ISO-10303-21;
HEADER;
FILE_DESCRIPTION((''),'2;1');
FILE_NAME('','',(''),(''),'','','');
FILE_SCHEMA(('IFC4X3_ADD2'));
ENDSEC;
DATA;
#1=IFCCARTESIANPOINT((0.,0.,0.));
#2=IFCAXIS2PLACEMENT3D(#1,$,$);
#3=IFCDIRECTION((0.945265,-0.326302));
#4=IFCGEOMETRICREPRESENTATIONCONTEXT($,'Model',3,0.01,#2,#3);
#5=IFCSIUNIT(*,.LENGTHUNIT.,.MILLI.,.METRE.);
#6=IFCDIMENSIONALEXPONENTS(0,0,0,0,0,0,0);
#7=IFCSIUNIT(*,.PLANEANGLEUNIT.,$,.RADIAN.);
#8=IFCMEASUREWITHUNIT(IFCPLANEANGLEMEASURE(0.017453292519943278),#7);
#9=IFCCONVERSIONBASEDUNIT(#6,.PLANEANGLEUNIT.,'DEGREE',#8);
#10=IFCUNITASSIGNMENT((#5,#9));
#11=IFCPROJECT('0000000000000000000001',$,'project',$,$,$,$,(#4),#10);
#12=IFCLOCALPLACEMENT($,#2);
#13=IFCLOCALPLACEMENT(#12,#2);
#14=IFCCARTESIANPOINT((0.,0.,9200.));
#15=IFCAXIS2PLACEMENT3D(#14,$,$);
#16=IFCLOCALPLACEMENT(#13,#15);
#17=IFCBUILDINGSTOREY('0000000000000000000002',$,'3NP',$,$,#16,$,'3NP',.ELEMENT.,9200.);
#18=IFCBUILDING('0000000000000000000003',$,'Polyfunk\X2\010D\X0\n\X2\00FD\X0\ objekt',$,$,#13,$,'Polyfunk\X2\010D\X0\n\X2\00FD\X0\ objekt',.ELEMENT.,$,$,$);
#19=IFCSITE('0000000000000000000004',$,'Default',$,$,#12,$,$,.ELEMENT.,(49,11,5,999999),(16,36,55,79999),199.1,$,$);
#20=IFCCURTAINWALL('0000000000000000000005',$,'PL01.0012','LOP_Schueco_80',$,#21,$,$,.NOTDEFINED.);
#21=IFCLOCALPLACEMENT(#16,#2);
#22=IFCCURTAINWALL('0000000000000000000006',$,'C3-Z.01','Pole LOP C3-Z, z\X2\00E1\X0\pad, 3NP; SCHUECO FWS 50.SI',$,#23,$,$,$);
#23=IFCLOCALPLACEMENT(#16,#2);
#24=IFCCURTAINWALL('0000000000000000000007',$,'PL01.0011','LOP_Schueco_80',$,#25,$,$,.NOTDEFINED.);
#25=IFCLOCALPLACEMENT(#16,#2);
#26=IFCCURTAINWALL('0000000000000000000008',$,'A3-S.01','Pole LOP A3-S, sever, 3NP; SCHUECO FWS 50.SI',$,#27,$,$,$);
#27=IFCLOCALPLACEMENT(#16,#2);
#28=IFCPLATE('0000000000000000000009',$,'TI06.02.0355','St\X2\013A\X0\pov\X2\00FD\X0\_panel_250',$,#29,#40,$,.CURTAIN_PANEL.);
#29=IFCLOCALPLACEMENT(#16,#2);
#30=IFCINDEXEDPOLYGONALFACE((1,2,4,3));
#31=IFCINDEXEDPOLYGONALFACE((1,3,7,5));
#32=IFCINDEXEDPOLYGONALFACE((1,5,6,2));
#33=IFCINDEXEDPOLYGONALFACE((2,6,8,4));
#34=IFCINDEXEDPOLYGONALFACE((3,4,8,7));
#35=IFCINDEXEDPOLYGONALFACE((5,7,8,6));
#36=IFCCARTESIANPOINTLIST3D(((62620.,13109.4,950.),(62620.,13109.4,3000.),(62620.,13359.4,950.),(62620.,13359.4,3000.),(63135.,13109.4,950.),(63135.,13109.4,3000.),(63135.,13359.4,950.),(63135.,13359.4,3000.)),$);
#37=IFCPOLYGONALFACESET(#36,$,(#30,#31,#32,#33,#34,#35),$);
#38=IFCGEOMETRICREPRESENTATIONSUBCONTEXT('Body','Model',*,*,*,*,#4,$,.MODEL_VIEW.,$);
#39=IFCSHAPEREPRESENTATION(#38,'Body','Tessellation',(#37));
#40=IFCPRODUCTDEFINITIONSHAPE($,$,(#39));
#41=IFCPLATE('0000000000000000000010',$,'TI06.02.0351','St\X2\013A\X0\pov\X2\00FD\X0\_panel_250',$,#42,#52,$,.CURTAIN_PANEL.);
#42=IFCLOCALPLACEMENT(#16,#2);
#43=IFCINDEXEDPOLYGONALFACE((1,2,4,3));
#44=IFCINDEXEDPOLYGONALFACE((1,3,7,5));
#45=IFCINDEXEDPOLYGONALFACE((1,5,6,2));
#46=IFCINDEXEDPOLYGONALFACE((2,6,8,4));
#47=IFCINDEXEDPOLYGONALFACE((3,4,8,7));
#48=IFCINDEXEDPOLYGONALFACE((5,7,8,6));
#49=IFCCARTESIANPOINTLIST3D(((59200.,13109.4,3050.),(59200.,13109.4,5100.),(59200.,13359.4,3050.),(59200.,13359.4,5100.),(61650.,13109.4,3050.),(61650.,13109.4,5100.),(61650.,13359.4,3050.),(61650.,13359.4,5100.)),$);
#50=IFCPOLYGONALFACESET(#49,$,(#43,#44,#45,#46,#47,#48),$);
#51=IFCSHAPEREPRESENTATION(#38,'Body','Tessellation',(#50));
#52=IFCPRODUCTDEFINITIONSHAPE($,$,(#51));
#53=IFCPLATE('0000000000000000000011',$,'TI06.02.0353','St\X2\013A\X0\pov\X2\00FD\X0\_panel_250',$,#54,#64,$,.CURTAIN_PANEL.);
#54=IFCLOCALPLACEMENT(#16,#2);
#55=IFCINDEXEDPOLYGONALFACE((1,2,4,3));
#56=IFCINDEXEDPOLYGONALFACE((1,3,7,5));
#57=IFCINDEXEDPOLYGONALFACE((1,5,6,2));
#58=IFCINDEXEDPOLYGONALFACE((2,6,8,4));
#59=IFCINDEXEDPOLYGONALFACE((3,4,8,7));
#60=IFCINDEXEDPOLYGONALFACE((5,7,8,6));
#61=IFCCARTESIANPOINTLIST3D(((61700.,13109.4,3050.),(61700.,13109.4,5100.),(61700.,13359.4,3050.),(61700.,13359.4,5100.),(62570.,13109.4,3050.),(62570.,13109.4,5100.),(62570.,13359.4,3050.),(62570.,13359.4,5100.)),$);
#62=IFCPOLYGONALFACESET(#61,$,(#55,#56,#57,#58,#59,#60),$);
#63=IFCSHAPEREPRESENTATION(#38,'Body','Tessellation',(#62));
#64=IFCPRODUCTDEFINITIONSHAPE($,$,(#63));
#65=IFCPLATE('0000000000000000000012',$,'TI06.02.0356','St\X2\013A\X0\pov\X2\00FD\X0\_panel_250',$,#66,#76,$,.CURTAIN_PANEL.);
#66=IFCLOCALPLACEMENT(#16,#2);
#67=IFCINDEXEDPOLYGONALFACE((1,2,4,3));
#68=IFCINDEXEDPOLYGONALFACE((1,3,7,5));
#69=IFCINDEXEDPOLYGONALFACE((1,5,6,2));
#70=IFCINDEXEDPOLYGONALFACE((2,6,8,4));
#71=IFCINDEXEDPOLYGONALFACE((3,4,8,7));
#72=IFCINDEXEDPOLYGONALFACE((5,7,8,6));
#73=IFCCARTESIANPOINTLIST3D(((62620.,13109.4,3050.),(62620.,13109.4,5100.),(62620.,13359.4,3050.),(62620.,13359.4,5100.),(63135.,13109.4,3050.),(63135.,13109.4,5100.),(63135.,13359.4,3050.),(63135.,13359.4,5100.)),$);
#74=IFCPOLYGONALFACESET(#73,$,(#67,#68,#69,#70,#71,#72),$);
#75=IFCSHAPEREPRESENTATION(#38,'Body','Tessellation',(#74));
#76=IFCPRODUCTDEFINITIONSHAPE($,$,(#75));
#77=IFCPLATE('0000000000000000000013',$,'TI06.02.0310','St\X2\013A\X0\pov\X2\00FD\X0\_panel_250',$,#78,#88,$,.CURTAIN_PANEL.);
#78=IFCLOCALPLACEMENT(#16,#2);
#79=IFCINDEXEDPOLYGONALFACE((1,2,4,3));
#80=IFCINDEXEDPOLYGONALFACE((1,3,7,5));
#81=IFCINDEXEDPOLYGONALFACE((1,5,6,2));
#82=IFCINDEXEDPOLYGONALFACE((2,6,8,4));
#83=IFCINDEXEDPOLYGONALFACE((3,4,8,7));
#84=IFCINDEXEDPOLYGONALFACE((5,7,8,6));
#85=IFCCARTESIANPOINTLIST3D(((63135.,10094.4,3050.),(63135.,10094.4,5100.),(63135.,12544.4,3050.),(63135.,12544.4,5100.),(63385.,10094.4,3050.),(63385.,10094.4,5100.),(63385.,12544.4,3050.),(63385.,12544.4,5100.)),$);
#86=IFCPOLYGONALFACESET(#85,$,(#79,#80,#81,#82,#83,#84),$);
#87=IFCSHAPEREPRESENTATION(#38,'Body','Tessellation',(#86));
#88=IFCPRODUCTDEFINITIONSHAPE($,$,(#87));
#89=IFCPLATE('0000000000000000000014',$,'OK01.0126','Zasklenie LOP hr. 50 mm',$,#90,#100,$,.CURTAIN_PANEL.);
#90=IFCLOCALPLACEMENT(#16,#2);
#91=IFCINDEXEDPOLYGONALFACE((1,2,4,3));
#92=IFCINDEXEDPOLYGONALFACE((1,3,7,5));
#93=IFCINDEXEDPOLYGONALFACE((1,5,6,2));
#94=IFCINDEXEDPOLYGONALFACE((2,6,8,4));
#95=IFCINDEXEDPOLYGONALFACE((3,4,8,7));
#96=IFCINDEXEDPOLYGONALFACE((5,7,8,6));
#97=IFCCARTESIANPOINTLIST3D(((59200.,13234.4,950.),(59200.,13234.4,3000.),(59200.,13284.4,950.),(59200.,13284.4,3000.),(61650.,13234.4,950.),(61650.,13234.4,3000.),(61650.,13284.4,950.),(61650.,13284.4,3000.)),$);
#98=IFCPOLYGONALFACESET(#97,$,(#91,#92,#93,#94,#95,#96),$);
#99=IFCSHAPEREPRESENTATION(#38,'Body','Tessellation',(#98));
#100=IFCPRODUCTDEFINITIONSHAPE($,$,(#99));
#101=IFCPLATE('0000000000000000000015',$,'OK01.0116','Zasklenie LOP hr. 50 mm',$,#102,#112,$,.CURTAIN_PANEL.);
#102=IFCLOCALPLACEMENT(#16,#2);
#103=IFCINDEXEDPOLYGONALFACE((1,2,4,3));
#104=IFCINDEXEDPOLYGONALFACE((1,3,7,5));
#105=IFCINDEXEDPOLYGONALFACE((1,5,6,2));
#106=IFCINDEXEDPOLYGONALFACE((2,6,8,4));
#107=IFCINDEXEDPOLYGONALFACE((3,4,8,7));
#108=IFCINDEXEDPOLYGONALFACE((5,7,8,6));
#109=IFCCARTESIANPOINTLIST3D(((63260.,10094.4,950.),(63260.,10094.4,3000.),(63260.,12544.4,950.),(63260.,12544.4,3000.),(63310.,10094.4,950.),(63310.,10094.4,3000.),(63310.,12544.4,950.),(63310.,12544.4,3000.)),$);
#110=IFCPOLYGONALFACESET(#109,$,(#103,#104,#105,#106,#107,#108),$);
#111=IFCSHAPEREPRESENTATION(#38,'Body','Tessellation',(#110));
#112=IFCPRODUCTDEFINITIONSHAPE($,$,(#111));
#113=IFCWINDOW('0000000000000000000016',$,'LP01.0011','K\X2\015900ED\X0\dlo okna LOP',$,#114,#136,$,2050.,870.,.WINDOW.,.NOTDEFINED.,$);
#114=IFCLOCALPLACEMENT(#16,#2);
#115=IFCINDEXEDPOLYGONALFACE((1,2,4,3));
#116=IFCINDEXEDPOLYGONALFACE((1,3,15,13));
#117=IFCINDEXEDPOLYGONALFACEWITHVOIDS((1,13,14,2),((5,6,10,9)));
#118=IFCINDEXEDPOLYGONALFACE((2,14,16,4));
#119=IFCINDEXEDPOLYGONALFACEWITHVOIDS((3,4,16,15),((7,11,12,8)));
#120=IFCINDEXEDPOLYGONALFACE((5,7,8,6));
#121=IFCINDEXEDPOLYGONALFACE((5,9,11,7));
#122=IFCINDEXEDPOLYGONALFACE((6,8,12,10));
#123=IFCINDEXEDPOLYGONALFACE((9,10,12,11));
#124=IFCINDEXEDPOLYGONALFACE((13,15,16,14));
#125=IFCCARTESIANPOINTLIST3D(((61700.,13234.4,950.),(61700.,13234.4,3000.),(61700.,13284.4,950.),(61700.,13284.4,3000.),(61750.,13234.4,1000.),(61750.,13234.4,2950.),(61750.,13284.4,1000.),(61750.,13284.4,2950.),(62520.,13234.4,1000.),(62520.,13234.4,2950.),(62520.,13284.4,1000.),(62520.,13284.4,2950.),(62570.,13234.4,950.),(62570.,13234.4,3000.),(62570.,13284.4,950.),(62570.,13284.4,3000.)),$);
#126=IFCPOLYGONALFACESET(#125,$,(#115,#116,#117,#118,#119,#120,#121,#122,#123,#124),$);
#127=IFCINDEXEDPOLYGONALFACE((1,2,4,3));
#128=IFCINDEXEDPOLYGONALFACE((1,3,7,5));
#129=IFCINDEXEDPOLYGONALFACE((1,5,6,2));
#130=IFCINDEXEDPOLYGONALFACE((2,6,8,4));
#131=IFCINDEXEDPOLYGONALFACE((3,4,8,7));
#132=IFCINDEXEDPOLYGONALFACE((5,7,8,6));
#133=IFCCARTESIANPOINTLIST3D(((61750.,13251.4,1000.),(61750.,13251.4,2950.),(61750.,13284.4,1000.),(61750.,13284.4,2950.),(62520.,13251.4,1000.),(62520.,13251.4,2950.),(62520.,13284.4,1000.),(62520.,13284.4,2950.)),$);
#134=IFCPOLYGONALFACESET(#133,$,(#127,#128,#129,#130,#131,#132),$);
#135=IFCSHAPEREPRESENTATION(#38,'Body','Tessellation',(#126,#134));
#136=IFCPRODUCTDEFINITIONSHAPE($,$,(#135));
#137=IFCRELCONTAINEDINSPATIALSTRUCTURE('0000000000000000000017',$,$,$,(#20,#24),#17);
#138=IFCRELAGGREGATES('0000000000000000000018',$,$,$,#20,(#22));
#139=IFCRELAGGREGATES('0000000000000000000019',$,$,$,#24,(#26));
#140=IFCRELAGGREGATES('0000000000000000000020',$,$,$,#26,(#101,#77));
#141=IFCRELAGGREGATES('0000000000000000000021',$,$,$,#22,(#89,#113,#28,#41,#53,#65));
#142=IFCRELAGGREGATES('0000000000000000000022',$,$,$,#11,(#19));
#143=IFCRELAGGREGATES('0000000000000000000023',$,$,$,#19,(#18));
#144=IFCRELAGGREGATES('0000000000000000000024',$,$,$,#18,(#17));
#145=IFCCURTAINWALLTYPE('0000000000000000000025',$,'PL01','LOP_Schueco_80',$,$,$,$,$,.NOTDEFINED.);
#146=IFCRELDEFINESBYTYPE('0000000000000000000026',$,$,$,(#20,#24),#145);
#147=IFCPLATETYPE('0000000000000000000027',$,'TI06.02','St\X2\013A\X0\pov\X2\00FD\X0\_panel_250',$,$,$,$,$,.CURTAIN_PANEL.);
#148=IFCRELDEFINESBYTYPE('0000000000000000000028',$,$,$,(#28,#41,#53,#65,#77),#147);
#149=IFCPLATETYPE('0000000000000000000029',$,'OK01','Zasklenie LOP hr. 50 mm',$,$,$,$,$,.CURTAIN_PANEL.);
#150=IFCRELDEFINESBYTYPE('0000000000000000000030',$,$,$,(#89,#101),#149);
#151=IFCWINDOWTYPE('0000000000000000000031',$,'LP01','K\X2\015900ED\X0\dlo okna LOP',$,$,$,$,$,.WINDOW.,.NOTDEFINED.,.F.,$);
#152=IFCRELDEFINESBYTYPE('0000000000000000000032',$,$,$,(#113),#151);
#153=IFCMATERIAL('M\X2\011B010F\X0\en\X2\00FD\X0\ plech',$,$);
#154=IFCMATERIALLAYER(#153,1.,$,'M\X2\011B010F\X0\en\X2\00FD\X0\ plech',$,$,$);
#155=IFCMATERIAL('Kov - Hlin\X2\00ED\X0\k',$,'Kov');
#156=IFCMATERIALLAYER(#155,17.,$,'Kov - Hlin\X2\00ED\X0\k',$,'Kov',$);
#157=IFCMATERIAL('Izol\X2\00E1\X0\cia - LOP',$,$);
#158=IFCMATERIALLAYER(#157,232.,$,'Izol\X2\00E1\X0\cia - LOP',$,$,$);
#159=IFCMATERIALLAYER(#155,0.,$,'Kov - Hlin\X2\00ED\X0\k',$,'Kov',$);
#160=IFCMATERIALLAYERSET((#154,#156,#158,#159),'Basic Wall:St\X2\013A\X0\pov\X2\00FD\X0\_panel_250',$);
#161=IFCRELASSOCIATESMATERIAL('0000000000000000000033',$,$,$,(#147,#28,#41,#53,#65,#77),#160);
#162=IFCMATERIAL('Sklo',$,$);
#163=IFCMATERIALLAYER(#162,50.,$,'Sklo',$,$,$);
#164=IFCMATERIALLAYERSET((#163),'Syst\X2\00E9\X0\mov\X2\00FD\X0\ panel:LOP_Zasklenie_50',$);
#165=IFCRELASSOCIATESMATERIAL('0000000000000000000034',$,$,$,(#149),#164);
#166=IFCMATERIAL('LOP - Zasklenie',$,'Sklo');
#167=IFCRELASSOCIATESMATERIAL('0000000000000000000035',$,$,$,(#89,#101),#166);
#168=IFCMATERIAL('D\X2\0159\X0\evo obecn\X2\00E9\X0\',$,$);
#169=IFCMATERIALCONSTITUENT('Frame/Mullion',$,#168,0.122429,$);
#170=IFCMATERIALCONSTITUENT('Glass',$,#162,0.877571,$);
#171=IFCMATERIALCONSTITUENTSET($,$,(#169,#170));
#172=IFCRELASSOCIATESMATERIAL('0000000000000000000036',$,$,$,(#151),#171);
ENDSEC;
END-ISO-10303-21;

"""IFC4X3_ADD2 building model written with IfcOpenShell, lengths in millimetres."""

from ifc_helpers import new_model, entity, si_unit, converted_unit, direction, frame, frame_2d, origin, origin_2d_with_axis, place, context, subcontext, project, spatial, polyline, rectangle, outline, extrude, source, transform, mapped, material, layer, layer_set, layer_usage, constituent, constituent_set, type_object, type_shapes, element, aggregate, save


model = new_model("IFC4X3_ADD2")

# Units and contexts
model_context = context("Model", 3, precision=0.01, world=origin(), true_north=direction((0.945265, -0.326302)))
body_context = subcontext(model_context, "Body", "Model", "MODEL_VIEW")
ifc_project = project(units=[si_unit("LENGTHUNIT", "METRE", prefix="MILLI"), converted_unit("PLANEANGLEUNIT", "DEGREE", entity("IfcPlaneAngleMeasure", 0.017453292519943278), si_unit("PLANEANGLEUNIT", "RADIAN"), dimensions=[0, 0, 0, 0, 0, 0, 0])], contexts=[model_context])

# Site, building, storey
site_placement = place(None, origin())
site = spatial("IfcSite", under=ifc_project, at=site_placement, Name="Default", CompositionType="ELEMENT", RefLatitude=(49, 11, 5, 999999), RefLongitude=(16, 36, 55, 79999), RefElevation=199.1)
building_placement = place(site_placement, origin())
building = spatial("IfcBuilding", under=site, at=building_placement, Name="Polyfunkčný objekt", LongName="Polyfunkčný objekt", CompositionType="ELEMENT")
storey_placement = place(building_placement, frame((0.0, 0.0, 9200.0)))
storey = spatial("IfcBuildingStorey", under=building, at=storey_placement, Name="3NP", LongName="3NP", CompositionType="ELEMENT", Elevation=9200.0)

# Curtain walls
curtain_wall_type = type_object("IfcCurtainWallType", Name="PL01", Description="LOP_Schueco_80", PredefinedType="NOTDEFINED")
curtain_wall_1_placement = place(storey_placement, frame((0.0, 0.0, -9200.0)))
curtain_wall_1 = element("IfcCurtainWall", 1, at=curtain_wall_1_placement, inside=storey, type_object=curtain_wall_type, Name="PL01.0012", Description="LOP_Schueco_80", PredefinedType="NOTDEFINED")
curtain_wall_2 = element("IfcCurtainWall", 2, Name="C3-Z.01", Description="Pole LOP C3-Z, západ, 3NP; SCHUECO FWS 50.SI")
aggregate(curtain_wall_1, [curtain_wall_2])
curtain_wall_3_placement = place(storey_placement, frame((0.0, 0.0, -9200.0)))
curtain_wall_3 = element("IfcCurtainWall", 3, at=curtain_wall_3_placement, inside=storey, type_object=curtain_wall_type, Name="PL01.0011", Description="LOP_Schueco_80", PredefinedType="NOTDEFINED")
curtain_wall_4 = element("IfcCurtainWall", 4, Name="A3-S.01", Description="Pole LOP A3-S, sever, 3NP; SCHUECO FWS 50.SI")
aggregate(curtain_wall_3, [curtain_wall_4])

# Plates
ifc_material_1 = material(Name="Měďený plech")
ifc_layer_1 = layer(ifc_material_1, 1.0, Name="Měďený plech")
ifc_material_2 = material(Name="Kov - Hliník", Category="Kov")
ifc_layer_2 = layer(ifc_material_2, 17.0, Name="Kov - Hliník", Category="Kov")
ifc_material_3 = material(Name="Izolácia - LOP")
ifc_layer_3 = layer(ifc_material_3, 232.0, Name="Izolácia - LOP")
ifc_layer_4 = layer(ifc_material_2, 0.0, Name="Kov - Hliník", Category="Kov")
ifc_layer_set_1 = layer_set([ifc_layer_1, ifc_layer_2, ifc_layer_3, ifc_layer_4], Name="Basic Wall:Stĺpový_panel_250")
ifc_layer_usage_1 = layer_usage(ifc_layer_set_1, "AXIS2", "NEGATIVE", 125.0)
plate_type_1 = type_object("IfcPlateType", Name="TI06.02", Description="Stĺpový_panel_250", PredefinedType="CURTAIN_PANEL", material=ifc_layer_set_1)
plate_1_placement = place(storey_placement, frame((62620.0, 13234.4, 950.0)))
plate_1 = element("IfcPlate", 5, at=plate_1_placement, type_object=plate_type_1, material=ifc_layer_usage_1, Name="TI06.02.0355", Description="Stĺpový_panel_250", PredefinedType="CURTAIN_PANEL", context=body_context, shape_type="SweptSolid", body=[
    extrude(rectangle(XDim=250.0, YDim=515.0, at=frame_2d((0.0, 0.0), x_axis=(1.0, 0.0))), frame((257.5, 0.0, 0.0), z_axis=(0.0, 0.0, 1.0), x_axis=(0.0, 1.0, 0.0)), (0.0, 0.0, 1.0), 2050.0),
])
ifc_layer_usage_2 = layer_usage(ifc_layer_set_1, "AXIS2", "NEGATIVE", 125.0)
plate_2_placement = place(storey_placement, frame((59200.0, 13234.4, 3050.0)))
plate_2 = element("IfcPlate", 6, at=plate_2_placement, type_object=plate_type_1, material=ifc_layer_usage_2, Name="TI06.02.0351", Description="Stĺpový_panel_250", PredefinedType="CURTAIN_PANEL", context=body_context, shape_type="SweptSolid", body=[
    extrude(rectangle(XDim=250.0, YDim=2450.0, at=frame_2d((0.0, 0.0), x_axis=(1.0, 0.0))), frame((1225.0, 0.0, 0.0), z_axis=(0.0, 0.0, 1.0), x_axis=(0.0, 1.0, 0.0)), (0.0, 0.0, 1.0), 2050.0),
])
ifc_layer_usage_3 = layer_usage(ifc_layer_set_1, "AXIS2", "NEGATIVE", 125.0)
plate_3_placement = place(storey_placement, frame((61700.0, 13234.4, 3050.0)))
plate_3 = element("IfcPlate", 7, at=plate_3_placement, type_object=plate_type_1, material=ifc_layer_usage_3, Name="TI06.02.0353", Description="Stĺpový_panel_250", PredefinedType="CURTAIN_PANEL", context=body_context, shape_type="SweptSolid", body=[
    extrude(rectangle(XDim=250.0, YDim=870.0, at=frame_2d((0.0, 0.0), x_axis=(1.0, 0.0))), frame((435.0, 0.0, 0.0), z_axis=(0.0, 0.0, 1.0), x_axis=(0.0, 1.0, 0.0)), (0.0, 0.0, 1.0), 2050.0),
])
ifc_layer_usage_4 = layer_usage(ifc_layer_set_1, "AXIS2", "NEGATIVE", 125.0)
plate_4_placement = place(storey_placement, frame((62620.0, 13234.4, 3050.0)))
plate_4 = element("IfcPlate", 8, at=plate_4_placement, type_object=plate_type_1, material=ifc_layer_usage_4, Name="TI06.02.0356", Description="Stĺpový_panel_250", PredefinedType="CURTAIN_PANEL", context=body_context, shape_type="SweptSolid", body=[
    extrude(rectangle(XDim=250.0, YDim=515.0, at=frame_2d((0.0, 0.0), x_axis=(1.0, 0.0))), frame((257.5, 0.0, 0.0), z_axis=(0.0, 0.0, 1.0), x_axis=(0.0, 1.0, 0.0)), (0.0, 0.0, 1.0), 2050.0),
])
ifc_layer_usage_5 = layer_usage(ifc_layer_set_1, "AXIS2", "NEGATIVE", 125.0)
plate_5_placement = place(storey_placement, frame((63260.0, 12544.4, 3050.0), z_axis=(0.0, 0.0, 1.0), x_axis=(0.0, -1.0, 0.0)))
plate_5 = element("IfcPlate", 9, at=plate_5_placement, type_object=plate_type_1, material=ifc_layer_usage_5, Name="TI06.02.0310", Description="Stĺpový_panel_250", PredefinedType="CURTAIN_PANEL", context=body_context, shape_type="SweptSolid", body=[
    extrude(rectangle(XDim=250.0, YDim=2450.0, at=frame_2d((0.0, 0.0), x_axis=(1.0, 0.0))), frame((1225.0, 0.0, 0.0), z_axis=(0.0, 0.0, 1.0), x_axis=(0.0, 1.0, 0.0)), (0.0, 0.0, 1.0), 2050.0),
])
ifc_material_4 = material(Name="LOP - Zasklenie", Category="Sklo")
ifc_material_5 = material(Name="Sklo")
ifc_layer_5 = layer(ifc_material_5, 50.0, Name="Sklo")
ifc_layer_set_2 = layer_set([ifc_layer_5], Name="Systémový panel:LOP_Zasklenie_50")
plate_type_2 = type_object("IfcPlateType", Name="OK01", Description="Zasklenie LOP hr. 50 mm", PredefinedType="CURTAIN_PANEL", material=ifc_layer_set_2)
shared_shape_1 = source(origin(), body_context, "Body", "SweptSolid", [
    extrude(rectangle(XDim=50.0, YDim=2450.0, at=origin_2d_with_axis()), frame((0.0, 25.0, 0.0), z_axis=(0.0, 0.0, 1.0), x_axis=(0.0, 1.0, 0.0)), (0.0, 0.0, 1.0), 2050.0),
])
type_shapes(plate_type_2, [shared_shape_1])
plate_6_placement = place(curtain_wall_1_placement, frame((60425.0, 13234.4, 10150.0)))
plate_6 = element("IfcPlate", 10, at=plate_6_placement, type_object=plate_type_2, material=ifc_material_4, Name="OK01.0126", Description="Zasklenie LOP hr. 50 mm", PredefinedType="CURTAIN_PANEL", context=body_context, shape_type="MappedRepresentation", body=[
    mapped(shared_shape_1, transform((0.0, 0.0, 0.0), scale=1.0)),
])
plate_7_placement = place(curtain_wall_3_placement, frame((63260.0, 11319.4, 10150.0), z_axis=(0.0, 0.0, 1.0), x_axis=(0.0, -1.0, 0.0)))
plate_7 = element("IfcPlate", 11, at=plate_7_placement, type_object=plate_type_2, material=ifc_material_4, Name="OK01.0116", Description="Zasklenie LOP hr. 50 mm", PredefinedType="CURTAIN_PANEL", context=body_context, shape_type="MappedRepresentation", body=[
    mapped(shared_shape_1, transform((0.0, 0.0, 0.0), scale=1.0)),
])
aggregate(curtain_wall_4, [plate_7, plate_5])

# Window
ifc_material_6 = material(Name="Dřevo obecné")
ifc_constituent_1 = constituent(ifc_material_6, Name="Frame/Mullion", fraction=0.122429)
ifc_constituent_2 = constituent(ifc_material_5, Name="Glass", fraction=0.877571)
ifc_constituent_set = constituent_set(constituents=[ifc_constituent_1, ifc_constituent_2])
window_type = type_object("IfcWindowType", Name="LP01", Description="Křídlo okna LOP", ParameterTakesPrecedence=False, PartitioningType="NOTDEFINED", PredefinedType="WINDOW", material=ifc_constituent_set)
shared_shape_2 = source(origin(), body_context, "Body", "SweptSolid", [
    extrude(outline(polyline([(-1025.0, -435.0), (1025.0, -435.0), (1025.0, 435.0), (-1025.0, 435.0), (-1025.0, -435.0)]), holes=[polyline([(-975.0, -385.0), (-975.0, 385.0), (975.0, 385.0), (975.0, -385.0), (-975.0, -385.0)])]), frame((0.0, 0.0, 1025.0), z_axis=(0.0, 1.0, 0.0), x_axis=(0.0, 0.0, -1.0)), (0.0, 0.0, 1.0), 50.0),
    extrude(rectangle(XDim=33.0, YDim=770.0, at=origin_2d_with_axis()), frame((0.0, 33.5, 50.0), z_axis=(0.0, 0.0, 1.0), x_axis=(0.0, -1.0, 0.0)), (0.0, 0.0, 1.0), 1950.0),
])
type_shapes(window_type, [shared_shape_2])
window_placement = place(curtain_wall_1_placement, frame((62135.0, 13234.4, 10150.0)))
window = element("IfcWindow", 12, at=window_placement, type_object=window_type, Name="LP01.0011", Description="Křídlo okna LOP", OverallHeight=2050.0, OverallWidth=870.0, PartitioningType="NOTDEFINED", PredefinedType="WINDOW", context=body_context, shape_type="MappedRepresentation", body=[
    mapped(shared_shape_2, transform((0.0, 0.0, 0.0), scale=1.0)),
])
aggregate(curtain_wall_2, [plate_6, window, plate_1, plate_2, plate_3, plate_4])

save(model, "model.ifc")
